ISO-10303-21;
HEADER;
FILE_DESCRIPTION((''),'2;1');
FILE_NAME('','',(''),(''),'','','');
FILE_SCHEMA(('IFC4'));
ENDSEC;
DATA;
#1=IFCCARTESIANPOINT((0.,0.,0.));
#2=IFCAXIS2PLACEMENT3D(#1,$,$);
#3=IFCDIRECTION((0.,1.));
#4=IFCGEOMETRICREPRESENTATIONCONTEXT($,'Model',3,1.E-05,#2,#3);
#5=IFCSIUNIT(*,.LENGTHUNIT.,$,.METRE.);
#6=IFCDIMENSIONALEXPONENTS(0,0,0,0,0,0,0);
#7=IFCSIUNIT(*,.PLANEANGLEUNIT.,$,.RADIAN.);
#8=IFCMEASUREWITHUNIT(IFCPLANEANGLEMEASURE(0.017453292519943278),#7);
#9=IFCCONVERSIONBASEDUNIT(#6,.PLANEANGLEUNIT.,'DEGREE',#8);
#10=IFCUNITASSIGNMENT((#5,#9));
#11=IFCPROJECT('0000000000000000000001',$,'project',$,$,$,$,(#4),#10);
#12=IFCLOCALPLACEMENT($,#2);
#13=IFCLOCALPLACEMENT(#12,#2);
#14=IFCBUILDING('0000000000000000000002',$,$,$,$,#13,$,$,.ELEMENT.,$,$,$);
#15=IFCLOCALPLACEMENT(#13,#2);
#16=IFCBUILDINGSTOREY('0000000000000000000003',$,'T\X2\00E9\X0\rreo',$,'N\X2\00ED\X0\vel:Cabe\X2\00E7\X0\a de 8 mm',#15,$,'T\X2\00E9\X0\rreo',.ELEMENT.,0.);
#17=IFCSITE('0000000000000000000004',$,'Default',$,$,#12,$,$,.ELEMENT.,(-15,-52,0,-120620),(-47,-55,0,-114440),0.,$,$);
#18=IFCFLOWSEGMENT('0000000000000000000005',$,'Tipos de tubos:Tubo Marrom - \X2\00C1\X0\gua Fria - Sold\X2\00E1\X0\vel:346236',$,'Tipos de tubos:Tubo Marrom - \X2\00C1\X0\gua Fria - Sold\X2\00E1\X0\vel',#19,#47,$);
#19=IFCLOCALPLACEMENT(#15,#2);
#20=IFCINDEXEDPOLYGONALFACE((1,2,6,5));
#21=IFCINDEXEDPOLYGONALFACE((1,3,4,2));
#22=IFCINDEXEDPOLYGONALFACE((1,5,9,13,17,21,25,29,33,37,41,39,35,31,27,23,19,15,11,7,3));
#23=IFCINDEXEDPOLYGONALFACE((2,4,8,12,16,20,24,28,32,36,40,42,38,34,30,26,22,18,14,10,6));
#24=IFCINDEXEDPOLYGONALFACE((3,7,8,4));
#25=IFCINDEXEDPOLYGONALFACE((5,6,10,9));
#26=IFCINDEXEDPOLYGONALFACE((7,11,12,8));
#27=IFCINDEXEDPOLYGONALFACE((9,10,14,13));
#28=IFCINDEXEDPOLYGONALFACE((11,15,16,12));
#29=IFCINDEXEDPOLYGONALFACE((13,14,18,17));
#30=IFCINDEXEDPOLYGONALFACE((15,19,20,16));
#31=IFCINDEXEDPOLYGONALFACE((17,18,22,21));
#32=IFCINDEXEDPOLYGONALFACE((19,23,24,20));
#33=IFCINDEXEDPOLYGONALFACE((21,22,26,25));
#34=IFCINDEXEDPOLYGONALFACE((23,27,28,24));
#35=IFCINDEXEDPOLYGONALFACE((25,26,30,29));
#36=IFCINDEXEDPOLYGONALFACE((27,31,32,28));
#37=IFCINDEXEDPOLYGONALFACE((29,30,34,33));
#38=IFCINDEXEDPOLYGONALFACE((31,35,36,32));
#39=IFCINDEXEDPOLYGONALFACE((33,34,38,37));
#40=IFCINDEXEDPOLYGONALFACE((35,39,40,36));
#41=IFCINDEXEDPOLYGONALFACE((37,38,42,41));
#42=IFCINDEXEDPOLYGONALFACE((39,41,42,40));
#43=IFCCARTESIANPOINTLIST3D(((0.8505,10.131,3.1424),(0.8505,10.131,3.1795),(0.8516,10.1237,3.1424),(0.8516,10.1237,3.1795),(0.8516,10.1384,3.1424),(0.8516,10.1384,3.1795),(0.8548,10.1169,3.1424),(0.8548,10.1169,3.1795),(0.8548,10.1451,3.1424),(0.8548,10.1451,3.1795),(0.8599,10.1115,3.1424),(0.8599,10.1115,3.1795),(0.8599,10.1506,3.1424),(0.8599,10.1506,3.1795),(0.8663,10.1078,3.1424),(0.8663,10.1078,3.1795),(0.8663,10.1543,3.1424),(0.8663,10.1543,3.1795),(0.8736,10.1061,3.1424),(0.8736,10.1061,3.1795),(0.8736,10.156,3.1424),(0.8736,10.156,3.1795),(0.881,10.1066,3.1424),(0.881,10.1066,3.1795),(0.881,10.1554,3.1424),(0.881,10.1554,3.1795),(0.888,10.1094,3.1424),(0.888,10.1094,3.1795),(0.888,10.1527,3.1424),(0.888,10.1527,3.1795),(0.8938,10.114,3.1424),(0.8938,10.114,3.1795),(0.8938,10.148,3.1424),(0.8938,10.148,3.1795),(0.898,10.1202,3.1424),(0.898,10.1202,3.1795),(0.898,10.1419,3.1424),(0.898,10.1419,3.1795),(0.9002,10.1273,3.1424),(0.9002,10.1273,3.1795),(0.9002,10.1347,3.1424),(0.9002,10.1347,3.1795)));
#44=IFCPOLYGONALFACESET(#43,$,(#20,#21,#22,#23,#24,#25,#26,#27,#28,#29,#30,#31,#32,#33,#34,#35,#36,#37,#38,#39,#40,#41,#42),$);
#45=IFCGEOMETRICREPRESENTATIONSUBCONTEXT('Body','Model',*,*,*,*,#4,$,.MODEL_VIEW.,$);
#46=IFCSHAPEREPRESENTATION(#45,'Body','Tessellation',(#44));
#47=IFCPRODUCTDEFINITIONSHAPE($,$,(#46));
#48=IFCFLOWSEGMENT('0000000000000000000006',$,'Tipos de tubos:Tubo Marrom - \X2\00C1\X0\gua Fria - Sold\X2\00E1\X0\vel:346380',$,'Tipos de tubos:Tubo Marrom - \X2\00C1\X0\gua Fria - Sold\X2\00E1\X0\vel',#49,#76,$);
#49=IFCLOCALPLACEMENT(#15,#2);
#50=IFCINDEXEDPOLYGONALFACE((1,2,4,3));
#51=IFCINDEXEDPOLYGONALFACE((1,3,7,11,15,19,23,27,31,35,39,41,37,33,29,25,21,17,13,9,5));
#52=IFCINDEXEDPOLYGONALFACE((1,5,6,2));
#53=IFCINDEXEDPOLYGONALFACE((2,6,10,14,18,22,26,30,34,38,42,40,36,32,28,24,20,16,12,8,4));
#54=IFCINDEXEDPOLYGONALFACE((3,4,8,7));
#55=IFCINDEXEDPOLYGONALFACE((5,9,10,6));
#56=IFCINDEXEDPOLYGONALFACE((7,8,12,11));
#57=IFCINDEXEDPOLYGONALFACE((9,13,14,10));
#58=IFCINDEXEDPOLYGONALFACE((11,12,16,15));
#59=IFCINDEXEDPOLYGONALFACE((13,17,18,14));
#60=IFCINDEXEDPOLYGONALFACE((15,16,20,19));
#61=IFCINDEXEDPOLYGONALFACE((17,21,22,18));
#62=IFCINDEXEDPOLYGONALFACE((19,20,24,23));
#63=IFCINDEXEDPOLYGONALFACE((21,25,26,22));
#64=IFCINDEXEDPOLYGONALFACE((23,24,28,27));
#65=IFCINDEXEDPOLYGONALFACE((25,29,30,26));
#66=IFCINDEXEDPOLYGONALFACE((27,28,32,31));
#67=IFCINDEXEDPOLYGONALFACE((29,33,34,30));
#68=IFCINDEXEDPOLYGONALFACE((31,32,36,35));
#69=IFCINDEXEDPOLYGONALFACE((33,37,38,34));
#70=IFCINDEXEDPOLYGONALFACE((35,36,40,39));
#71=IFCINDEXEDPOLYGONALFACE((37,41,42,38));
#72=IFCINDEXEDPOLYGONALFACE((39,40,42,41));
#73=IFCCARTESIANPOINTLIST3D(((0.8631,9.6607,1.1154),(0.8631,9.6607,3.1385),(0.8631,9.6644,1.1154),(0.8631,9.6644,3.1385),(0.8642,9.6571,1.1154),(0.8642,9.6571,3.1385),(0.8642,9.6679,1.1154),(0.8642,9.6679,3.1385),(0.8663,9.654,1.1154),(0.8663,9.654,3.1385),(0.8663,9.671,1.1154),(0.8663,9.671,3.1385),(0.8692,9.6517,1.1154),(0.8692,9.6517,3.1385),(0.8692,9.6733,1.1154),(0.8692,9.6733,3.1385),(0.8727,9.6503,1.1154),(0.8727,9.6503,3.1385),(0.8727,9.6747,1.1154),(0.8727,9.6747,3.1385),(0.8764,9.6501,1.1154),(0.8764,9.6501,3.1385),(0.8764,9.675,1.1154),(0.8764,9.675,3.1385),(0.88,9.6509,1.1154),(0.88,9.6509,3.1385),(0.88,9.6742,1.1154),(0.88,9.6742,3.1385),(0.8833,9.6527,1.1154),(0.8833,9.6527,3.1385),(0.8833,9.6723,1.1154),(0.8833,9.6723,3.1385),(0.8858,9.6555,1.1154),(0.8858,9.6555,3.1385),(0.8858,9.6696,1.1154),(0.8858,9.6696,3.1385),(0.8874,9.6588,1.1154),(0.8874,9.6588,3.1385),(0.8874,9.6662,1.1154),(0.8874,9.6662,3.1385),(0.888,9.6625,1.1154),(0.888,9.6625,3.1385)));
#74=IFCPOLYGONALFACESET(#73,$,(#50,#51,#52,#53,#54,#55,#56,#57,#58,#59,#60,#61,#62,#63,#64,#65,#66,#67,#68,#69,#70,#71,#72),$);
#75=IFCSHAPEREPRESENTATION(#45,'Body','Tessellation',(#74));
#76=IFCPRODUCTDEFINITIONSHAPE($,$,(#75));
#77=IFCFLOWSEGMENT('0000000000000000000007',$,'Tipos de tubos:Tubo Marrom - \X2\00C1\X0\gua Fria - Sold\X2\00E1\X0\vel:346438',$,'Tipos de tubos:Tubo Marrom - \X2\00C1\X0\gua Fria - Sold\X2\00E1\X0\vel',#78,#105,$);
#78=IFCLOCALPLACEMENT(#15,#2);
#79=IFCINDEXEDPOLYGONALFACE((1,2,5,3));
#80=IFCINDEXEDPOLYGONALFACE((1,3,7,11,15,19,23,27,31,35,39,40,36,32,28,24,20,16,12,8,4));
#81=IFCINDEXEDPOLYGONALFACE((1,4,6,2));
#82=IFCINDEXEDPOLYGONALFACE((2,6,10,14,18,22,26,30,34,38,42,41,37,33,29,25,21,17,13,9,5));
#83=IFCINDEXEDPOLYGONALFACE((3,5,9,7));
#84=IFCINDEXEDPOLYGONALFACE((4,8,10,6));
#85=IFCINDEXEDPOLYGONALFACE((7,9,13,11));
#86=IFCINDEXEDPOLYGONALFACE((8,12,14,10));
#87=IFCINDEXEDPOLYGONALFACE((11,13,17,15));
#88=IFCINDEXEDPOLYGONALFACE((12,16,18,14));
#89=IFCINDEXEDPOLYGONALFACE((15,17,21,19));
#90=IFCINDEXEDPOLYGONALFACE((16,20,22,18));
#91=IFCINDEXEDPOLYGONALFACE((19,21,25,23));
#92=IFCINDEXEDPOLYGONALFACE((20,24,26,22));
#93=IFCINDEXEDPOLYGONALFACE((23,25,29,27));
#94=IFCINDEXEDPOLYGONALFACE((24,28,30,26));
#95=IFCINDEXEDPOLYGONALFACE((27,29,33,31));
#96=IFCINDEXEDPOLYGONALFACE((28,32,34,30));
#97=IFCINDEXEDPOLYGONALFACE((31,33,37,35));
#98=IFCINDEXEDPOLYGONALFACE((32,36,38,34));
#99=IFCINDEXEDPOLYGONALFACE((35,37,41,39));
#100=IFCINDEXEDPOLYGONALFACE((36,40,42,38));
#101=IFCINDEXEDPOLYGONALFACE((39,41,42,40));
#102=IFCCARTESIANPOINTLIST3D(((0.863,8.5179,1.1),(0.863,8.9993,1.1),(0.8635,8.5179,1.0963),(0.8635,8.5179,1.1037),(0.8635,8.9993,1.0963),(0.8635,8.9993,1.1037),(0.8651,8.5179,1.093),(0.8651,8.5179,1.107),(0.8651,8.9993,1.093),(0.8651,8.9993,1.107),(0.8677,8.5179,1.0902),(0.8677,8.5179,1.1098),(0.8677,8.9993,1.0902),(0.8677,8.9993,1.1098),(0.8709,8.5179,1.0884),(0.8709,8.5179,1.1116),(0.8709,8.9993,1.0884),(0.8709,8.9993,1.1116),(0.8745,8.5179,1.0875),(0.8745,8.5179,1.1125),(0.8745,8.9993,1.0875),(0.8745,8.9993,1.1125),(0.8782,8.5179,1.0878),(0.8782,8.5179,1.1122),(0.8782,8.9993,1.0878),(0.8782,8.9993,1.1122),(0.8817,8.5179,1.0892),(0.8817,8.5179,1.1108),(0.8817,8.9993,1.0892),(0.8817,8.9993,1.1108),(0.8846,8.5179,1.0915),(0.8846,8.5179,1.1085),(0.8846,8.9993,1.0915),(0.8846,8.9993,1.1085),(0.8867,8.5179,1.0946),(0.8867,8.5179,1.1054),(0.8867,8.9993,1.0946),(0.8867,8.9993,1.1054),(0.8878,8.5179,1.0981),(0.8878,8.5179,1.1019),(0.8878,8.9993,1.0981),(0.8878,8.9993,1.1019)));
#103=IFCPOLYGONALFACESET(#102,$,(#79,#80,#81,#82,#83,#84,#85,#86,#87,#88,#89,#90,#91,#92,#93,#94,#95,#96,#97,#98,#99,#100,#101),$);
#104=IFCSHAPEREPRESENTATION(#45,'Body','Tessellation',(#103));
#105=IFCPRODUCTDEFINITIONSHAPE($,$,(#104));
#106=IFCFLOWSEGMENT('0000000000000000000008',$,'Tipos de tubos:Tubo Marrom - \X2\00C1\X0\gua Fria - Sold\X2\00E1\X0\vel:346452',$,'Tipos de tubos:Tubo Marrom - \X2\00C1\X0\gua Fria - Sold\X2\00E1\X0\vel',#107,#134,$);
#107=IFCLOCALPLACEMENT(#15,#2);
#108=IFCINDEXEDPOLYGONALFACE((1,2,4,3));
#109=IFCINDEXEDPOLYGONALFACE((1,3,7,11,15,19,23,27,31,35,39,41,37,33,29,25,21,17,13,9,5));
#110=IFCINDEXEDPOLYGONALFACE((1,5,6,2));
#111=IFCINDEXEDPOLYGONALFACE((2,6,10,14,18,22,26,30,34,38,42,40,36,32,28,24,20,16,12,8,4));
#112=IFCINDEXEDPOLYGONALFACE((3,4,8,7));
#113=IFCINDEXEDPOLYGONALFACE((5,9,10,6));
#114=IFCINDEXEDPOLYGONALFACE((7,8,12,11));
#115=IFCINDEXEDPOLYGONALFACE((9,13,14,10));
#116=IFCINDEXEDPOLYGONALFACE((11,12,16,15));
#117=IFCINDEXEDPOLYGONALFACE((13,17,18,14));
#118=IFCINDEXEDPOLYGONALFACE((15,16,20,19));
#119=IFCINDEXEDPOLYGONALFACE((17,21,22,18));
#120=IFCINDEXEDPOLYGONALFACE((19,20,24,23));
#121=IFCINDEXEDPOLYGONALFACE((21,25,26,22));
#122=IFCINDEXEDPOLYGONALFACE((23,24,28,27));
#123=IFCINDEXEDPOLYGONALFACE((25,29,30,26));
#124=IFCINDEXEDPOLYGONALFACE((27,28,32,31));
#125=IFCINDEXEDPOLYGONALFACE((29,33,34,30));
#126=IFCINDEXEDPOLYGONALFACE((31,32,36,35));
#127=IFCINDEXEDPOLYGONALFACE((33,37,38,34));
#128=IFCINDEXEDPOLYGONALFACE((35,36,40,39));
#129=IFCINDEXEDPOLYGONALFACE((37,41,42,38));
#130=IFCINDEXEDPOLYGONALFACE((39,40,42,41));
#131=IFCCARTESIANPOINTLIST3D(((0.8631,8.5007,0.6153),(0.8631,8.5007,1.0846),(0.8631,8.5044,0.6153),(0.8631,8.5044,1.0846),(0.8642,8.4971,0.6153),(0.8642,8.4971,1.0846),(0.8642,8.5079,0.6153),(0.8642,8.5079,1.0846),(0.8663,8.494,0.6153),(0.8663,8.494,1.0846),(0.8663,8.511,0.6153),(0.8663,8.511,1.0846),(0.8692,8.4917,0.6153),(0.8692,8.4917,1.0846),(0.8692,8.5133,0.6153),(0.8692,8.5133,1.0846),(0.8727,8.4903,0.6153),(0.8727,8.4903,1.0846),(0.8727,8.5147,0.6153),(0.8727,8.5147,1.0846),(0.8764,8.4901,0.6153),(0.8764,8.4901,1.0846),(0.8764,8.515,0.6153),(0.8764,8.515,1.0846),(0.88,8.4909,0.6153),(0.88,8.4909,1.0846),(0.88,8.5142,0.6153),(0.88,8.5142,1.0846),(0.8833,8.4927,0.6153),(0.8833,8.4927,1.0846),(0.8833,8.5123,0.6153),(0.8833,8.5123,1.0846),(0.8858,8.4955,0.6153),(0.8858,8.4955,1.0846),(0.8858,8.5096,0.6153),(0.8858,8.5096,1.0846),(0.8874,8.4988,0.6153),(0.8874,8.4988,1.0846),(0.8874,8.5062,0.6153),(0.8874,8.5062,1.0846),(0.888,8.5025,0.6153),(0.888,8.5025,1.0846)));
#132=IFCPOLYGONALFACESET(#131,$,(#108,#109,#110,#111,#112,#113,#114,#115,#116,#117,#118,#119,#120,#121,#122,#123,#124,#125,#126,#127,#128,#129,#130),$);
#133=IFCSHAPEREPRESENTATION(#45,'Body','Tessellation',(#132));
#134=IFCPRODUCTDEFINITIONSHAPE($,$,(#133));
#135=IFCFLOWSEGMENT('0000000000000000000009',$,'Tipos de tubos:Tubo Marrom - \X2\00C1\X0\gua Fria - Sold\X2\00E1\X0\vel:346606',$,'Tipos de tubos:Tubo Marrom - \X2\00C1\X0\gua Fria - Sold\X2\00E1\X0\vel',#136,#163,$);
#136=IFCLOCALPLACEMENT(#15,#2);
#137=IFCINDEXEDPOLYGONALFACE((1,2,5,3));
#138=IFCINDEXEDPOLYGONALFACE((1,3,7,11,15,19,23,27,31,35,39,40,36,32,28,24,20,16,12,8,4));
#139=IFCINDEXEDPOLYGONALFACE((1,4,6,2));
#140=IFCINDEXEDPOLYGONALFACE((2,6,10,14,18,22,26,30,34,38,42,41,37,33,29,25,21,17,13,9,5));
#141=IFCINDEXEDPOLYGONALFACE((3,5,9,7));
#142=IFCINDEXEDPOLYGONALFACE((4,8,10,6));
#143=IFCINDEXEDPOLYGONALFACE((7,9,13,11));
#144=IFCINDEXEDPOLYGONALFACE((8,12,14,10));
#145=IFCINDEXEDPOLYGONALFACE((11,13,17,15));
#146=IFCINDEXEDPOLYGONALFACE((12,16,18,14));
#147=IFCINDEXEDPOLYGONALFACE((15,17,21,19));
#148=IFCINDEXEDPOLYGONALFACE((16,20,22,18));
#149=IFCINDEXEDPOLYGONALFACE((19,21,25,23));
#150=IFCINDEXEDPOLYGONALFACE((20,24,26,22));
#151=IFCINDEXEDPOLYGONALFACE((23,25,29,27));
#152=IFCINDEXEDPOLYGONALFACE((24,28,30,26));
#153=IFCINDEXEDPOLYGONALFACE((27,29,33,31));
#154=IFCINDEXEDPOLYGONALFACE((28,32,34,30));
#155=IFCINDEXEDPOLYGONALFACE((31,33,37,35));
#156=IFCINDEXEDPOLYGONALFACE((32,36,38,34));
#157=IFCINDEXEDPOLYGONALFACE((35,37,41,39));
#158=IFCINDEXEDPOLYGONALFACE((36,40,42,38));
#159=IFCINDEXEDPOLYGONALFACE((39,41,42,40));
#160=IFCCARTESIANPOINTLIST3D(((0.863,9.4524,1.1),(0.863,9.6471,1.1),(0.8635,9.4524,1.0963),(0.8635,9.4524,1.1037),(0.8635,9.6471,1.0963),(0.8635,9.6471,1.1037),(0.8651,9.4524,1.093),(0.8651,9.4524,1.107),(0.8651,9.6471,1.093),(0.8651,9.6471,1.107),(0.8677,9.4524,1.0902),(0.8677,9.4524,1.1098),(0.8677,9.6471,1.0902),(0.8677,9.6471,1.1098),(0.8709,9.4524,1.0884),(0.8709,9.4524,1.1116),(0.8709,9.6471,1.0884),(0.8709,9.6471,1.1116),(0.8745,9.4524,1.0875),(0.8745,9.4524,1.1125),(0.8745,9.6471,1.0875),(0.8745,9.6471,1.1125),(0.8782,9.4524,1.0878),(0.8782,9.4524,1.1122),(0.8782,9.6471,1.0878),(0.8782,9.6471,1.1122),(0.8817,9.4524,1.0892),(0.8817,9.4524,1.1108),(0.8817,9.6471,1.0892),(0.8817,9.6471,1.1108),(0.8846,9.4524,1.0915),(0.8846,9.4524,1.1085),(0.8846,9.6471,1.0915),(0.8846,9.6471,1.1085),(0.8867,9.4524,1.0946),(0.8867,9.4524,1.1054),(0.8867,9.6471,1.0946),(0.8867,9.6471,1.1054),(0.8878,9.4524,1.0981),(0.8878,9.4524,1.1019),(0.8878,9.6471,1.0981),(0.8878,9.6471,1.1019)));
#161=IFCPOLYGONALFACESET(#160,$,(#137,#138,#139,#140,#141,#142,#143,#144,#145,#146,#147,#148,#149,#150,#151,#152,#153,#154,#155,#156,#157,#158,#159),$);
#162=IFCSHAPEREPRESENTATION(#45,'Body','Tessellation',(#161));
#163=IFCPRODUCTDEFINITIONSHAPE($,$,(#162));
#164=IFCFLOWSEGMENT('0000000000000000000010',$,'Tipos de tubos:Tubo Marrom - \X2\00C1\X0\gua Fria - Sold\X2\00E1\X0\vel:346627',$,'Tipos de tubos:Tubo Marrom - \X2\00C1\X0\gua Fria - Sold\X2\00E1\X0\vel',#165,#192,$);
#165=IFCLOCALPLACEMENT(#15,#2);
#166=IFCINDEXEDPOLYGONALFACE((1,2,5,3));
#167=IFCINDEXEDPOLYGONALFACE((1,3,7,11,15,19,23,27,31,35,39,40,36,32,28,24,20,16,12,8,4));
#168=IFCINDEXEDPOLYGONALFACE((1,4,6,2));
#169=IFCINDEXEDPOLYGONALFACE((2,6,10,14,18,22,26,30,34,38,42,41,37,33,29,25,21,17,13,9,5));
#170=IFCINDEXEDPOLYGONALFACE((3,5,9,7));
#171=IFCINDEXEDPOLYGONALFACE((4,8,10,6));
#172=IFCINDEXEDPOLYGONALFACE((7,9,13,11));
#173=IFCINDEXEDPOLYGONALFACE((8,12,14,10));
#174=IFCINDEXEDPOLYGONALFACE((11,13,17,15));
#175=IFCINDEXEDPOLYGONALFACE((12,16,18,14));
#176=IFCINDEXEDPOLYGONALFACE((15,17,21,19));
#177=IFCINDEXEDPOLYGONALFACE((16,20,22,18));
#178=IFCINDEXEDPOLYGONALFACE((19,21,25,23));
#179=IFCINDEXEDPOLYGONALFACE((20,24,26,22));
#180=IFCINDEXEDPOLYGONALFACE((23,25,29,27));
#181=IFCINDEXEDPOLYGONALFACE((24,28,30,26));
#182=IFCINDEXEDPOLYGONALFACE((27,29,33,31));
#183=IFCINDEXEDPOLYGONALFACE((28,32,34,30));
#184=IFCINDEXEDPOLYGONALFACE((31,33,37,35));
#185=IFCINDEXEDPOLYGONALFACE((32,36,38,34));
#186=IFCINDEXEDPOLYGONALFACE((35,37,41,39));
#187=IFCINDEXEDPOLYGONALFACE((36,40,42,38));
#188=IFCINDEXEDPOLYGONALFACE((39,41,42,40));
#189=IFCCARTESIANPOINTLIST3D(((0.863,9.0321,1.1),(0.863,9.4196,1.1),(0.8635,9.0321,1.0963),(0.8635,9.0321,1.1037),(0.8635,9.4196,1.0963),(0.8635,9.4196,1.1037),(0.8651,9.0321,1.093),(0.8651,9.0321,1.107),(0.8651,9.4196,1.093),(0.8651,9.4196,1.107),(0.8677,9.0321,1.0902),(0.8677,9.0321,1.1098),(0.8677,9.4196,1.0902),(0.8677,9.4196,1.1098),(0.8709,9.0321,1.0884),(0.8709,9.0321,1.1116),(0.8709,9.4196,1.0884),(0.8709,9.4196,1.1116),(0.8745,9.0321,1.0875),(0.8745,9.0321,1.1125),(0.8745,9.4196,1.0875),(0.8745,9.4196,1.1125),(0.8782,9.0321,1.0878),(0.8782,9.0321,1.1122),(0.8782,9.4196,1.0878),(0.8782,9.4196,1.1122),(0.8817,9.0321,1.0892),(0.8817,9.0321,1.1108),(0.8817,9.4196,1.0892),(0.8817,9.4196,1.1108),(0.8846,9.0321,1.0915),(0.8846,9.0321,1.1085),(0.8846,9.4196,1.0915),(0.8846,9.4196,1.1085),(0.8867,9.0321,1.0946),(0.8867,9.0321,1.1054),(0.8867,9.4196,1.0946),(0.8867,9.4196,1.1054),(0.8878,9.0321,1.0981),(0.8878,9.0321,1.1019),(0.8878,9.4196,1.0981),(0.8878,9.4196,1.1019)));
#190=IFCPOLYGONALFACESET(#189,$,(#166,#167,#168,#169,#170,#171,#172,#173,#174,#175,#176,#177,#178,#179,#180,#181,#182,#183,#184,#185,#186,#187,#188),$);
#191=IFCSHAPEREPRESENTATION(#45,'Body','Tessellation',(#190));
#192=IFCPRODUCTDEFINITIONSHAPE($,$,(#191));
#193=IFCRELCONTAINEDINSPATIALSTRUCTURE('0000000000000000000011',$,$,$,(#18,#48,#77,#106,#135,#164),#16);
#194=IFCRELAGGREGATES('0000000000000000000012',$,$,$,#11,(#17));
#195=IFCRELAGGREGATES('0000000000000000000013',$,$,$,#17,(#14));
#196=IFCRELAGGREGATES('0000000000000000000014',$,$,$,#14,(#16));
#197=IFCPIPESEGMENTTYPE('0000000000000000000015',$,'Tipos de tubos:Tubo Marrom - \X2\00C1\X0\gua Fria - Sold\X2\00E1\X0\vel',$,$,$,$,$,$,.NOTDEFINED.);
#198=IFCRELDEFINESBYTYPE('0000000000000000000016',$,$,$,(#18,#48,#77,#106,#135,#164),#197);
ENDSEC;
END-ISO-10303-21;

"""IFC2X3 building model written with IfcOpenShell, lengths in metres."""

from ifc_helpers import new_model, entity, si_unit, converted_unit, direction, frame, frame_2d, origin, origin_2d_with_axis, place, context, subcontext, project, spatial, circle, extrude, type_object, element, save


model = new_model("IFC2X3")

# Units and contexts
model_context = context("Model", 3, precision=1e-05, world=origin(), true_north=direction((0.0, 1.0)))
body_context = subcontext(model_context, "Body", "Model", "MODEL_VIEW")
ifc_project = project(units=[si_unit("LENGTHUNIT", "METRE"), converted_unit("PLANEANGLEUNIT", "DEGREE", entity("IfcPlaneAngleMeasure", 0.017453292519943278), si_unit("PLANEANGLEUNIT", "RADIAN"), dimensions=[0, 0, 0, 0, 0, 0, 0])], contexts=[model_context])

# Site, building, storey
site_placement = place(None, origin())
site = spatial("IfcSite", under=ifc_project, at=site_placement, Name="Default", CompositionType="ELEMENT", RefLatitude=(-15, -52, 0, -120620), RefLongitude=(-47, -55, 0, -114440), RefElevation=0.0)
building_placement = place(site_placement, origin())
building = spatial("IfcBuilding", under=site, at=building_placement, CompositionType="ELEMENT")
storey_placement = place(building_placement, origin())
storey = spatial("IfcBuildingStorey", under=building, at=storey_placement, Name="Térreo", ObjectType="Nível:Cabeça de 8 mm", LongName="Térreo", CompositionType="ELEMENT", Elevation=0.0)

# Flow segments
pipe_segment_type = type_object("IfcPipeSegmentType", Name="Tipos de tubos:Tubo Marrom - Água Fria - Soldável", PredefinedType="NOTDEFINED")
flow_segment_1_placement = place(storey_placement, origin())
element("IfcFlowSegment", 1, at=flow_segment_1_placement, inside=storey, type_object=pipe_segment_type, Name="Tipos de tubos:Tubo Marrom - Água Fria - Soldável:346236", ObjectType="Tipos de tubos:Tubo Marrom - Água Fria - Soldável", context=body_context, shape_type="SweptSolid", body=[
    extrude(circle(Radius=0.025, at=frame_2d((0.0, 0.0), x_axis=(1.0, 0.0))), frame((0.8755, 10.131, 3.1424), z_axis=(0.0, 0.0, 1.0), x_axis=(-1.0, 0.0, 0.0)), (0.0, 0.0, 1.0), 0.0371),
])
flow_segment_2_placement = place(storey_placement, origin())
element("IfcFlowSegment", 2, at=flow_segment_2_placement, inside=storey, type_object=pipe_segment_type, Name="Tipos de tubos:Tubo Marrom - Água Fria - Soldável:346380", ObjectType="Tipos de tubos:Tubo Marrom - Água Fria - Soldável", context=body_context, shape_type="SweptSolid", body=[
    extrude(circle(Radius=0.0125, at=origin_2d_with_axis()), frame((0.8755, 9.6625, 1.1154)), (0.0, 0.0, 1.0), 2.0231),
])
flow_segment_3_placement = place(storey_placement, origin())
element("IfcFlowSegment", 3, at=flow_segment_3_placement, inside=storey, type_object=pipe_segment_type, Name="Tipos de tubos:Tubo Marrom - Água Fria - Soldável:346438", ObjectType="Tipos de tubos:Tubo Marrom - Água Fria - Soldável", context=body_context, shape_type="SweptSolid", body=[
    extrude(circle(Radius=0.0125, at=frame_2d((0.0, 0.0), x_axis=(1.0, 0.0))), frame((0.8755, 8.5179, 1.1), z_axis=(0.0, 1.0, 0.0), x_axis=(-1.0, 0.0, 0.0)), (0.0, 0.0, 1.0), 0.4814),
])
flow_segment_4_placement = place(storey_placement, origin())
element("IfcFlowSegment", 4, at=flow_segment_4_placement, inside=storey, type_object=pipe_segment_type, Name="Tipos de tubos:Tubo Marrom - Água Fria - Soldável:346452", ObjectType="Tipos de tubos:Tubo Marrom - Água Fria - Soldável", context=body_context, shape_type="SweptSolid", body=[
    extrude(circle(Radius=0.0125, at=origin_2d_with_axis()), frame((0.8755, 8.5025, 0.6153)), (0.0, 0.0, 1.0), 0.4693),
])
flow_segment_5_placement = place(storey_placement, origin())
element("IfcFlowSegment", 5, at=flow_segment_5_placement, inside=storey, type_object=pipe_segment_type, Name="Tipos de tubos:Tubo Marrom - Água Fria - Soldável:346606", ObjectType="Tipos de tubos:Tubo Marrom - Água Fria - Soldável", context=body_context, shape_type="SweptSolid", body=[
    extrude(circle(Radius=0.0125, at=frame_2d((0.0, 0.0), x_axis=(1.0, 0.0))), frame((0.8755, 9.4524, 1.1), z_axis=(0.0, 1.0, 0.0), x_axis=(-1.0, 0.0, 0.0)), (0.0, 0.0, 1.0), 0.1947),
])
flow_segment_6_placement = place(storey_placement, origin())
element("IfcFlowSegment", 6, at=flow_segment_6_placement, inside=storey, type_object=pipe_segment_type, Name="Tipos de tubos:Tubo Marrom - Água Fria - Soldável:346627", ObjectType="Tipos de tubos:Tubo Marrom - Água Fria - Soldável", context=body_context, shape_type="SweptSolid", body=[
    extrude(circle(Radius=0.0125, at=frame_2d((0.0, 0.0), x_axis=(1.0, 0.0))), frame((0.8755, 9.0321, 1.1), z_axis=(0.0, 1.0, 0.0), x_axis=(-1.0, 0.0, 0.0)), (0.0, 0.0, 1.0), 0.3875),
])

save(model, "model.ifc")
